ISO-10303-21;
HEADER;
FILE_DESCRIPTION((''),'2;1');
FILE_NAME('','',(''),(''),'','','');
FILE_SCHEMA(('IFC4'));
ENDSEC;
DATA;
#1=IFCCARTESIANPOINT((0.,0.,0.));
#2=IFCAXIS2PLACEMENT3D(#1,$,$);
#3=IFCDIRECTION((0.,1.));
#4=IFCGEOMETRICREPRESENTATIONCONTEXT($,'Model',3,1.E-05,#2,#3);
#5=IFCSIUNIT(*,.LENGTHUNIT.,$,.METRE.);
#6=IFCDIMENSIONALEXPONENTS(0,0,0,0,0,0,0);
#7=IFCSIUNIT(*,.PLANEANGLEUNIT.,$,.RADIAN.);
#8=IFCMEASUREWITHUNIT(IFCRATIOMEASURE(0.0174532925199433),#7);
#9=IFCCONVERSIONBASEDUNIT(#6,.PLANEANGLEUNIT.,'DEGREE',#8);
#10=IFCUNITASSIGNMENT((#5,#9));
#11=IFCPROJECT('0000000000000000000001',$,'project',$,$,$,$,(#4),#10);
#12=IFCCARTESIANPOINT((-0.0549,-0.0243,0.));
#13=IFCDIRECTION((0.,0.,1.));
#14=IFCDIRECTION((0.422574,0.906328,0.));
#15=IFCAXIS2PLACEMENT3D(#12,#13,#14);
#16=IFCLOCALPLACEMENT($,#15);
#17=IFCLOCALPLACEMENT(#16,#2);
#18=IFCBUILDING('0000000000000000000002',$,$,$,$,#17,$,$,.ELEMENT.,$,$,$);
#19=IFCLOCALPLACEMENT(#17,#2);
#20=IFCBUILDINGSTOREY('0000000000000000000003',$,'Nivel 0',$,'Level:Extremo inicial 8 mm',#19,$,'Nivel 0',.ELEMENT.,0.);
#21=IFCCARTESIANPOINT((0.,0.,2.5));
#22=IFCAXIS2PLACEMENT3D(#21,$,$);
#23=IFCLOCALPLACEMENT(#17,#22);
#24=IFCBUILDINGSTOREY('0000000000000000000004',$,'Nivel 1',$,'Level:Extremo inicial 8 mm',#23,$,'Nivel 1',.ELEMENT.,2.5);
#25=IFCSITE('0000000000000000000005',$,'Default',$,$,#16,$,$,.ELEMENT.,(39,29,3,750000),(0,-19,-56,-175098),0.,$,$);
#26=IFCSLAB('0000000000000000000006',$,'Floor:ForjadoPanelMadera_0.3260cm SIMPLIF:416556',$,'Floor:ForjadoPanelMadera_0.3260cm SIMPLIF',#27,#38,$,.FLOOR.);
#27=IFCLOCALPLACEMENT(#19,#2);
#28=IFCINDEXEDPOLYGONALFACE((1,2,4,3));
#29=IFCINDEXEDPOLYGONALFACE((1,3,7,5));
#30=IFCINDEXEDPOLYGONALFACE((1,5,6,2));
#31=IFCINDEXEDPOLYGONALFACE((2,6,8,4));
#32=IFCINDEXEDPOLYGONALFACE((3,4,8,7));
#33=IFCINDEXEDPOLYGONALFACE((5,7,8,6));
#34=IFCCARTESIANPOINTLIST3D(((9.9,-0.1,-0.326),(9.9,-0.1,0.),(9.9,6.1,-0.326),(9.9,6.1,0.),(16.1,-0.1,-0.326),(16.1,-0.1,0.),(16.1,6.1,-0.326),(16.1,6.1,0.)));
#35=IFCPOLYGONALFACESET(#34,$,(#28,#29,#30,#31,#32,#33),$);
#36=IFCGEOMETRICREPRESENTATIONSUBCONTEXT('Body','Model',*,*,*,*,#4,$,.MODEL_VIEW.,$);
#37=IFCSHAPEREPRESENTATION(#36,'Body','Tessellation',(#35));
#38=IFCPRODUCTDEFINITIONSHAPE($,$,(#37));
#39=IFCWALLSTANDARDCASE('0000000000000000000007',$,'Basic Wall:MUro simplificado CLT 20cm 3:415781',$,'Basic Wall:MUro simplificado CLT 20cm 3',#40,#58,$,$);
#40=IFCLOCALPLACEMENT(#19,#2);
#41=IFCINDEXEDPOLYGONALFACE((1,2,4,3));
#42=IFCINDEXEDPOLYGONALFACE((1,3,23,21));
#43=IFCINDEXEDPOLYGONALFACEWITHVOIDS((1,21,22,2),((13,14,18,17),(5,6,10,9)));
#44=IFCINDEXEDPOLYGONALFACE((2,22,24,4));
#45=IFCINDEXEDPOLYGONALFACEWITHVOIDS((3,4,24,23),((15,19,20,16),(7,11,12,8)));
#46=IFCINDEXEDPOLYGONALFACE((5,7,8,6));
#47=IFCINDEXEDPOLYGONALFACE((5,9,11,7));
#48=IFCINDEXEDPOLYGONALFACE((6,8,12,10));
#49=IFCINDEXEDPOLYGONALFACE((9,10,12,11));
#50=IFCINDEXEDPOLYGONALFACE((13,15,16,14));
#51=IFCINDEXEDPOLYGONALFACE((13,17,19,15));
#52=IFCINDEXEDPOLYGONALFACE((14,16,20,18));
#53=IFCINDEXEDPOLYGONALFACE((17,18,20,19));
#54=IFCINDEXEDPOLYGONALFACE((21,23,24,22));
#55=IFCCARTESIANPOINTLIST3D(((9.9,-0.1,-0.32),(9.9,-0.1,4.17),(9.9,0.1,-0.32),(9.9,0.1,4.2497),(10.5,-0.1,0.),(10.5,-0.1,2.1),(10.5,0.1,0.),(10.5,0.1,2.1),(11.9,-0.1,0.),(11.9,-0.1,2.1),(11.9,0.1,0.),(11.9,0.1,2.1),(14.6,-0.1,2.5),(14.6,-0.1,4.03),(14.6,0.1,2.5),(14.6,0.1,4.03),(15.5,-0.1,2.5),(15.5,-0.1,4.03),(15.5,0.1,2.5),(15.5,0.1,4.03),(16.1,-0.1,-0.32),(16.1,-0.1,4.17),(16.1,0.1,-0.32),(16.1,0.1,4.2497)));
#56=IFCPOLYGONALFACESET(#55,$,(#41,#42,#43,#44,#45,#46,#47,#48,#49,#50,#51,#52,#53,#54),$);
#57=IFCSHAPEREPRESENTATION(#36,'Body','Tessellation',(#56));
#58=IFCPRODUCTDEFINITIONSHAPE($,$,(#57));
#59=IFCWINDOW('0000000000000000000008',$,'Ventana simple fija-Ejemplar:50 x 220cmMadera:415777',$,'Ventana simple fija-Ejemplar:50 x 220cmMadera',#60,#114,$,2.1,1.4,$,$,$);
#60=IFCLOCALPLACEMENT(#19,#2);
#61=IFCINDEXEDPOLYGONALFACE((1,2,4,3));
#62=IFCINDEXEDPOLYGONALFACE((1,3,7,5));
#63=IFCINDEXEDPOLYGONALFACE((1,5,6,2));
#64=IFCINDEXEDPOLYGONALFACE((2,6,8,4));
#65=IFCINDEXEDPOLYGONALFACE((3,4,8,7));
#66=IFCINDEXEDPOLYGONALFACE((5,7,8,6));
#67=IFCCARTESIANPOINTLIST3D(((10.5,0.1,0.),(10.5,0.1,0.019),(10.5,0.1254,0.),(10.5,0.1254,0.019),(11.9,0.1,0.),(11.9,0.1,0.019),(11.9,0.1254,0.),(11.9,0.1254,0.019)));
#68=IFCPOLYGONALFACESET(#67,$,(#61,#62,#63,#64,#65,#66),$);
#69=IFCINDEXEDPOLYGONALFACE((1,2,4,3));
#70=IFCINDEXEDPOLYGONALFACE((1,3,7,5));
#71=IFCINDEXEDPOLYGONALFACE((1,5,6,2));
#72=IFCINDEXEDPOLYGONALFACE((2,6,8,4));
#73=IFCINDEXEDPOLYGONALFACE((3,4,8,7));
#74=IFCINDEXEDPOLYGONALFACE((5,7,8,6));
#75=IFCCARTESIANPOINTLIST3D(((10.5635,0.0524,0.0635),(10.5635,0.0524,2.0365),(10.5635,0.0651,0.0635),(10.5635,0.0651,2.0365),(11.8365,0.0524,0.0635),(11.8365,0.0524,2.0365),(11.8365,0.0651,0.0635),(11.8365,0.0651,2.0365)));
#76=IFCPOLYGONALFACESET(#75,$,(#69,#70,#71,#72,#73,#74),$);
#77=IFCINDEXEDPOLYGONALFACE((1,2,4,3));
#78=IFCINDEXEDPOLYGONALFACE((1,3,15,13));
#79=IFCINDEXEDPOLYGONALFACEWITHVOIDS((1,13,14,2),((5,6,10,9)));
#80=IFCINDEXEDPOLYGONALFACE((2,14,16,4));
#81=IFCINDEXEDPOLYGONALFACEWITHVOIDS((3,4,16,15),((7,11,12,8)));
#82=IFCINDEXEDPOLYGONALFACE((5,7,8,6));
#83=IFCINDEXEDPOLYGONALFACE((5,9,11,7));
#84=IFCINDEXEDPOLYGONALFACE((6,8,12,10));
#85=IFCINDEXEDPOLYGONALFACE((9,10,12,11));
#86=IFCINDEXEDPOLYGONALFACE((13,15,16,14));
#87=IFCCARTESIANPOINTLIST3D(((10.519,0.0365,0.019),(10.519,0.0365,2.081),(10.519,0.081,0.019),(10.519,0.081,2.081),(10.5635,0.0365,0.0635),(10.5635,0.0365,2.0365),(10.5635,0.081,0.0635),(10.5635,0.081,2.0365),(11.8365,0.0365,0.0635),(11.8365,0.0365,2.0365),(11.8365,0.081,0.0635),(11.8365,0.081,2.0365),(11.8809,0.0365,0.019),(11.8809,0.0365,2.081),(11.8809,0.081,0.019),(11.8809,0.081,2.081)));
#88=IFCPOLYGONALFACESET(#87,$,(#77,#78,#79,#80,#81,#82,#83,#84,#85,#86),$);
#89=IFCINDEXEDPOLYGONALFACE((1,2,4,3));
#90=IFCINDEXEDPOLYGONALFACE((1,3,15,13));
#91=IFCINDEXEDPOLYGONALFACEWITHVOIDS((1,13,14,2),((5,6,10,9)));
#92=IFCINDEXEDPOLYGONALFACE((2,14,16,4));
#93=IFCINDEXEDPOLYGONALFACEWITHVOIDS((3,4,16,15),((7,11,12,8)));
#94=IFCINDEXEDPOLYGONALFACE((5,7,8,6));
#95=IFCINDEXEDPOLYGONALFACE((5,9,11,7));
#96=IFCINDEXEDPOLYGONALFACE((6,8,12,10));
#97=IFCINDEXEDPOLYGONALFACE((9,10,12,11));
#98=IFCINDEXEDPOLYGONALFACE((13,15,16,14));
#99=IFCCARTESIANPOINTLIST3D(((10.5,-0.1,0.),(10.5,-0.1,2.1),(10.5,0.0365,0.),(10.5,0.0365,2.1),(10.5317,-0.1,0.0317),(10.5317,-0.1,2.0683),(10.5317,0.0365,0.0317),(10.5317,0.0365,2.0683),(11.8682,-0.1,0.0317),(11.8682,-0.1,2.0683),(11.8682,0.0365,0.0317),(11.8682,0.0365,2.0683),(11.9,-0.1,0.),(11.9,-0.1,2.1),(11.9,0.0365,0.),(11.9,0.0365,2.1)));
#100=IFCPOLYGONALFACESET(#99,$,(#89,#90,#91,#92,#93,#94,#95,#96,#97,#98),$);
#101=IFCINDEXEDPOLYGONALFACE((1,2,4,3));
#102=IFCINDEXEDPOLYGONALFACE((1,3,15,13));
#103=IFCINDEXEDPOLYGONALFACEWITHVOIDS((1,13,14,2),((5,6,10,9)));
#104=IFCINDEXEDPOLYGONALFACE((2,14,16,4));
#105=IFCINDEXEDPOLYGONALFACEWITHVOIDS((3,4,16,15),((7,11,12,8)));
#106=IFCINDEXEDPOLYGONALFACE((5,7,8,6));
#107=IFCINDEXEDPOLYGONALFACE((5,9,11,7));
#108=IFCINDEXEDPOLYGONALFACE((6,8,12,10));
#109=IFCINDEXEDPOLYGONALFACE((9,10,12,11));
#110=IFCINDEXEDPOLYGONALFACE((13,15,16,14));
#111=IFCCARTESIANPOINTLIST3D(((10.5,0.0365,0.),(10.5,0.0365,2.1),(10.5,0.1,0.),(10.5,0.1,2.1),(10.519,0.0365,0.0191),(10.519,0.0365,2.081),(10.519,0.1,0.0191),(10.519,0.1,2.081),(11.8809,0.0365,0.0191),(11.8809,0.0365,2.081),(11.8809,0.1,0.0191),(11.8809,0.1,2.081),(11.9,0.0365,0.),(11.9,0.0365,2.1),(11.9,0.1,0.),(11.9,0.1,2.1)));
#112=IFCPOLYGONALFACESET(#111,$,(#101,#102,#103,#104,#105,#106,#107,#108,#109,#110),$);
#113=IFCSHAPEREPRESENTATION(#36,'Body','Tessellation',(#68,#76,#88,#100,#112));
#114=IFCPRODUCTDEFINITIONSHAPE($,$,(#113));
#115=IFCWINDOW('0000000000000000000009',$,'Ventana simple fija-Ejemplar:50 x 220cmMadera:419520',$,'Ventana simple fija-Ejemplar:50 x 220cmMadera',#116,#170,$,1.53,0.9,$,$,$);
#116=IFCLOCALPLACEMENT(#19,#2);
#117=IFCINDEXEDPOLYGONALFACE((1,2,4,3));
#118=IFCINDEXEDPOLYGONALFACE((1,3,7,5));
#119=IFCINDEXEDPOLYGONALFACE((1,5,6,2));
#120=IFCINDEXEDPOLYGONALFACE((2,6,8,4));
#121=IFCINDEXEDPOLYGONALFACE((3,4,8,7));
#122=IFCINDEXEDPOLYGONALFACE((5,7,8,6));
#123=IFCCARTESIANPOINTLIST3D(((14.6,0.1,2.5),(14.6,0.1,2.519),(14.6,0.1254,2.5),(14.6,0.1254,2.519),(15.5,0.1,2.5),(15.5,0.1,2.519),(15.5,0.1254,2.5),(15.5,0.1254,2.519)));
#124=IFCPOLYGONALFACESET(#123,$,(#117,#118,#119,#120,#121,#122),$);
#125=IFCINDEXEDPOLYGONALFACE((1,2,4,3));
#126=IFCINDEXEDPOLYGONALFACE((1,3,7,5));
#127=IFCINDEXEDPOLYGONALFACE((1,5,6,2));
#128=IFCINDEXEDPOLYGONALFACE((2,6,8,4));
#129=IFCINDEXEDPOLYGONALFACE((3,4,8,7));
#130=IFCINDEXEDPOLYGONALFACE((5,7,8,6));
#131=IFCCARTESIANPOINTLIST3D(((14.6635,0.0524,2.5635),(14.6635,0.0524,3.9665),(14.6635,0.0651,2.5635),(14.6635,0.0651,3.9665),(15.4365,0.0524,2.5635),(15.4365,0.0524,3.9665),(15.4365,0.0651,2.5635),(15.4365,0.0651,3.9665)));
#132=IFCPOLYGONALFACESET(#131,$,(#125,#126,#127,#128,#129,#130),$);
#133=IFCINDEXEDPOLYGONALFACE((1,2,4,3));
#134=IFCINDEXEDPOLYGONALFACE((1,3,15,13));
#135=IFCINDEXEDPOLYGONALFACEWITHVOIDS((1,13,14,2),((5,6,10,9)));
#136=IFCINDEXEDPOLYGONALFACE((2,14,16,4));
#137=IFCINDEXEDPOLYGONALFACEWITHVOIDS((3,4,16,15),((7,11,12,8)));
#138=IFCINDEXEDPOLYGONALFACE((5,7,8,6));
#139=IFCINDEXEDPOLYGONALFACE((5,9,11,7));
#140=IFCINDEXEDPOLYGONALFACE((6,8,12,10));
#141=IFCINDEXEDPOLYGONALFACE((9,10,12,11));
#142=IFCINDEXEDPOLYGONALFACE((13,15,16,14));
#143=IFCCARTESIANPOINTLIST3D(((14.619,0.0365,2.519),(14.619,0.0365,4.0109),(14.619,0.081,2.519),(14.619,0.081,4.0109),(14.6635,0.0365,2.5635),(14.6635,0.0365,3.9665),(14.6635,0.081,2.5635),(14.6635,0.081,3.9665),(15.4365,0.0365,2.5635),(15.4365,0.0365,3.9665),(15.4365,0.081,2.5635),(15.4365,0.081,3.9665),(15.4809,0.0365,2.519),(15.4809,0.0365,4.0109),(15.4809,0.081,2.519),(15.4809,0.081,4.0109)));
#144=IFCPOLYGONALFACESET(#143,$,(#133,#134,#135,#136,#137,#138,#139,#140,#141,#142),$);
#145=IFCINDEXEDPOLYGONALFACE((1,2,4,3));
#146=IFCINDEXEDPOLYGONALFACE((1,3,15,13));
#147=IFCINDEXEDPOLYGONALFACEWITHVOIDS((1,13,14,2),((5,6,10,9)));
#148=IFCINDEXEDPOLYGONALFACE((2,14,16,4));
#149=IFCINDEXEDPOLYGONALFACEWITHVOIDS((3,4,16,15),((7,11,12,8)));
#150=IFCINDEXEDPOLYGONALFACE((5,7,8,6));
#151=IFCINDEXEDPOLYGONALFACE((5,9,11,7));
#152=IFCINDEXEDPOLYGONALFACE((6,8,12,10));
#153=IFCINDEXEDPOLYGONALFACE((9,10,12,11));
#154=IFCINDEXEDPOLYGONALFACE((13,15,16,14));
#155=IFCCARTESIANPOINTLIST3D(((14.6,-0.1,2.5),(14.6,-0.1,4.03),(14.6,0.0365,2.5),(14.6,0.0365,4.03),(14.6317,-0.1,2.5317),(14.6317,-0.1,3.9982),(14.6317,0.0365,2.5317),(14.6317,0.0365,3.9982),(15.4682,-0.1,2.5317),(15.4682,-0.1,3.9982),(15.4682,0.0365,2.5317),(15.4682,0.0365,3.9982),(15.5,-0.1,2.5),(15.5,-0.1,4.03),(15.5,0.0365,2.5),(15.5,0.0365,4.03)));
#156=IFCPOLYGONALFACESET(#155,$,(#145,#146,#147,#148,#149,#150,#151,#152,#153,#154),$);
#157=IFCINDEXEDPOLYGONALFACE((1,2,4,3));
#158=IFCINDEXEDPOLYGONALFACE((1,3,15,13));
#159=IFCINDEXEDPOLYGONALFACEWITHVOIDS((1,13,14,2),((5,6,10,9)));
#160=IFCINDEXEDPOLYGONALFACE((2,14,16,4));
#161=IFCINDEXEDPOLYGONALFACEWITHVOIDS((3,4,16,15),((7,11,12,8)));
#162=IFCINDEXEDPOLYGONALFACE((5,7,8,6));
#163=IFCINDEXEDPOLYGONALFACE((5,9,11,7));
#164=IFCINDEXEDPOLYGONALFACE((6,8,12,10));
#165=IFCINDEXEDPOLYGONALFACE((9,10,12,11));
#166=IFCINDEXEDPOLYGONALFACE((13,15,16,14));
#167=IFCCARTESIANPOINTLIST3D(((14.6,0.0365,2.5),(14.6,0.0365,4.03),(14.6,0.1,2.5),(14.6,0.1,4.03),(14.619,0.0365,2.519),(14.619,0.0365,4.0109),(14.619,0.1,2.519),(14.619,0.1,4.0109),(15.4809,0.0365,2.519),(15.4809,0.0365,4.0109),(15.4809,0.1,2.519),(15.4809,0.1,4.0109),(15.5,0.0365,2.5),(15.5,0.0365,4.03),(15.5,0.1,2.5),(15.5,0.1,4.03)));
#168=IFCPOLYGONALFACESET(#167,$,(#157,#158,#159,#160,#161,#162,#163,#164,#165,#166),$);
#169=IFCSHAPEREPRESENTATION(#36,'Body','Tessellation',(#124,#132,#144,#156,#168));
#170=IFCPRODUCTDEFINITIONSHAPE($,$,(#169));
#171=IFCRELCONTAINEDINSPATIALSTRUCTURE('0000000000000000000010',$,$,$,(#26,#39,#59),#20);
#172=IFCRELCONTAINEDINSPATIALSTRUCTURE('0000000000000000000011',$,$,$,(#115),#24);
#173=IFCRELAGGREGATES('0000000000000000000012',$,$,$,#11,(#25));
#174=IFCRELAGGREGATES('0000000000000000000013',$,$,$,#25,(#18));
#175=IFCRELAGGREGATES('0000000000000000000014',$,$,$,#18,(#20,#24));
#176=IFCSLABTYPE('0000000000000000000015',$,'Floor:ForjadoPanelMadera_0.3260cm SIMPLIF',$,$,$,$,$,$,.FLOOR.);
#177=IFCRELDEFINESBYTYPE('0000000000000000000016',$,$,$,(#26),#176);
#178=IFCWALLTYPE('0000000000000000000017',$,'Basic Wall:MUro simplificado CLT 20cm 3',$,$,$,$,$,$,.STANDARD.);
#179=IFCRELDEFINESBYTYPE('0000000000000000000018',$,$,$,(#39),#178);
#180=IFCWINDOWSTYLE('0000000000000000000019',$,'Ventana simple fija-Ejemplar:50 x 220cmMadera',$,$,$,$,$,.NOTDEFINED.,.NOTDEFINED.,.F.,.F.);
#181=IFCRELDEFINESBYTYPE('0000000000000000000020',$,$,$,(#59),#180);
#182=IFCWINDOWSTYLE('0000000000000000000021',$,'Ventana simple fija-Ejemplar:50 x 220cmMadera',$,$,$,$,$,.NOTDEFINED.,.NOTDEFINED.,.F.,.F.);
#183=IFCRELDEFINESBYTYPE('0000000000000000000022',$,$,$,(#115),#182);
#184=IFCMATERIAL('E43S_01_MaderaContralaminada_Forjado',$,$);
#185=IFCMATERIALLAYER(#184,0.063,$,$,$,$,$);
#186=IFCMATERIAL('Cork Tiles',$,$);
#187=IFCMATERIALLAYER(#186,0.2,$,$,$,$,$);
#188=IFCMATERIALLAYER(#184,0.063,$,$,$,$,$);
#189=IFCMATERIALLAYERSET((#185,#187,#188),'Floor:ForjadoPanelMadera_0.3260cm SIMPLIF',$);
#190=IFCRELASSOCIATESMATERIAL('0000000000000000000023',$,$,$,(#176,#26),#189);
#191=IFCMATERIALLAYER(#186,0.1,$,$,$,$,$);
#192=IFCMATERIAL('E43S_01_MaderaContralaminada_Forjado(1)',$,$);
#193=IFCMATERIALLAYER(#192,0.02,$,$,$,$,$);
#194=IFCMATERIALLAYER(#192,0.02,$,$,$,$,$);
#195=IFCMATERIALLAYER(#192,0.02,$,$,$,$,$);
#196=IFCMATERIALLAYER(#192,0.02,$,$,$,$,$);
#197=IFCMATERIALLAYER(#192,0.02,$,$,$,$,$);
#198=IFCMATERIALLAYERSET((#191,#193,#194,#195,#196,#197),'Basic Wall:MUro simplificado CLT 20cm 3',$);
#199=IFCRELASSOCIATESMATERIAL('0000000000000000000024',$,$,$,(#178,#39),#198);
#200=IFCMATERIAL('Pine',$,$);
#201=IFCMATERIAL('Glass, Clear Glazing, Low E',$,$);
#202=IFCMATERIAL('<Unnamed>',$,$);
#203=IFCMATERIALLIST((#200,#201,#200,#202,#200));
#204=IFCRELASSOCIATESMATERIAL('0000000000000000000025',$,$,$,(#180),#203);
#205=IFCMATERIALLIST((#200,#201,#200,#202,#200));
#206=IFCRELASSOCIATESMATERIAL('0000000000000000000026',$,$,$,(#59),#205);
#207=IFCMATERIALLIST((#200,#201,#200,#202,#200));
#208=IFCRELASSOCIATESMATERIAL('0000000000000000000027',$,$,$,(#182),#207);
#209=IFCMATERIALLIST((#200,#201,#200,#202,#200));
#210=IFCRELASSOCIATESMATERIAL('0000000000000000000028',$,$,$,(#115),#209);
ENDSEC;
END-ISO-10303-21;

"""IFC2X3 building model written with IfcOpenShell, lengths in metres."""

from ifc_helpers import new_model, entity, si_unit, converted_unit, direction, frame, frame_2d, origin, origin_2d_with_axis, place, context, subcontext, project, spatial, polyline, rectangle, outline, extrude, clip, bounded_halfspace, source, transform, mapped, material, material_list, layer, layer_set, layer_usage, type_object, type_shapes, element, fill, save


model = new_model("IFC2X3")

# Units and contexts
model_context = context("Model", 3, precision=1e-05, world=origin(), true_north=direction((0.0, 1.0)))
body_context = subcontext(model_context, "Body", "Model", "MODEL_VIEW")
ifc_project = project(units=[si_unit("LENGTHUNIT", "METRE"), converted_unit("PLANEANGLEUNIT", "DEGREE", entity("IfcRatioMeasure", 0.0174532925199433), si_unit("PLANEANGLEUNIT", "RADIAN"), dimensions=[0, 0, 0, 0, 0, 0, 0])], contexts=[model_context])

# Site, building, storey
site_placement = place(None, frame((-0.0549, -0.0243, 0.0), z_axis=(0.0, 0.0, 1.0), x_axis=(0.422574, 0.906328, 0.0)))
site = spatial("IfcSite", under=ifc_project, at=site_placement, Name="Default", CompositionType="ELEMENT", RefLatitude=(39, 29, 3, 750000), RefLongitude=(0, -19, -56, -175098), RefElevation=0.0)
building_placement = place(site_placement, origin())
building = spatial("IfcBuilding", under=site, at=building_placement, CompositionType="ELEMENT")
storey_1_placement = place(building_placement, origin())
storey_1 = spatial("IfcBuildingStorey", under=building, at=storey_1_placement, Name="Nivel 0", ObjectType="Level:Extremo inicial 8 mm", LongName="Nivel 0", CompositionType="ELEMENT", Elevation=0.0)

# Slab
ifc_material_1 = material(Name="E43S_01_MaderaContralaminada_Forjado")
ifc_layer_1 = layer(ifc_material_1, 0.063)
ifc_material_2 = material(Name="Cork Tiles")
ifc_layer_2 = layer(ifc_material_2, 0.2)
ifc_layer_3 = layer(ifc_material_1, 0.063)
ifc_layer_set_1 = layer_set([ifc_layer_1, ifc_layer_2, ifc_layer_3], Name="Floor:ForjadoPanelMadera_0.3260cm SIMPLIF")
ifc_layer_usage_1 = layer_usage(ifc_layer_set_1, "AXIS3", "POSITIVE", 0.0)
slab_type = type_object("IfcSlabType", Name="Floor:ForjadoPanelMadera_0.3260cm SIMPLIF", PredefinedType="FLOOR", material=ifc_layer_set_1)
slab_placement = place(storey_1_placement, origin())
element("IfcSlab", 1, at=slab_placement, inside=storey_1, type_object=slab_type, material=ifc_layer_usage_1, Name="Floor:ForjadoPanelMadera_0.3260cm SIMPLIF:416556", ObjectType="Floor:ForjadoPanelMadera_0.3260cm SIMPLIF", PredefinedType="FLOOR", context=body_context, shape_type="SweptSolid", body=[
    extrude(rectangle(XDim=6.2, YDim=6.2, at=frame_2d((0.0, 0.0), x_axis=(1.0, 0.0))), frame((13.0, 3.0, 0.0), z_axis=(0.0, 0.0, -1.0), x_axis=(0.0, 1.0, 0.0)), (0.0, 0.0, 1.0), 0.326),
])

# Wall, openings, window
ifc_layer_4 = layer(ifc_material_2, 0.1)
ifc_material_3 = material(Name="E43S_01_MaderaContralaminada_Forjado(1)")
ifc_layer_5 = layer(ifc_material_3, 0.02)
ifc_layer_6 = layer(ifc_material_3, 0.02)
ifc_layer_7 = layer(ifc_material_3, 0.02)
ifc_layer_8 = layer(ifc_material_3, 0.02)
ifc_layer_9 = layer(ifc_material_3, 0.02)
ifc_layer_set_2 = layer_set([ifc_layer_4, ifc_layer_5, ifc_layer_6, ifc_layer_7, ifc_layer_8, ifc_layer_9], Name="Basic Wall:MUro simplificado CLT 20cm 3")
ifc_layer_usage_2 = layer_usage(ifc_layer_set_2, "AXIS2", "NEGATIVE", 0.1)
wall_type = type_object("IfcWallType", Name="Basic Wall:MUro simplificado CLT 20cm 3", PredefinedType="STANDARD", material=ifc_layer_set_2)
wall_1_placement = place(storey_1_placement, frame((16.1, 0.0, -0.32), z_axis=(0.0, 0.0, 1.0), x_axis=(-1.0, 0.0, 0.0)))
wall_1 = element("IfcWallStandardCase", 2, at=wall_1_placement, inside=storey_1, type_object=wall_type, material=ifc_layer_usage_2, Name="Basic Wall:MUro simplificado CLT 20cm 3:415781", ObjectType="Basic Wall:MUro simplificado CLT 20cm 3", context=body_context, shape_type="Clipping", body=[
    clip(extrude(rectangle(XDim=6.2, YDim=0.2, at=frame_2d((3.1, 0.0), x_axis=(-1.0, 0.0))), origin(), (0.0, 0.0, 1.0), 4.5697), bounded_halfspace(frame((0.0, -0.1, 4.5697), z_axis=(0.0, 0.370288, 0.928917), x_axis=(-1.0, 0.0, 0.0)), False, frame((0.0, -0.1, 4.5697)), polyline([(0.0, 0.0), (0.2, 0.0), (6.0, 0.0), (6.2, 0.0), (6.2, 0.2), (0.0, 0.2), (0.0, 0.0)]))),
])
opening_1_placement = place(wall_1_placement, frame((5.6, 0.1, 0.32)))
opening_1 = element("IfcOpeningElement", 3, at=opening_1_placement, cuts=wall_1, ObjectType="Opening", context=body_context, shape_type="SweptSolid", body=[
    extrude(rectangle(XDim=2.1, YDim=1.4, at=frame_2d((1.05, 0.7), x_axis=(-1.0, 0.0))), frame((0.0, 0.0, 0.0), z_axis=(0.0, -1.0, 0.0), x_axis=(0.0, 0.0, 1.0)), (0.0, 0.0, 1.0), 0.2),
])
opening_2_placement = place(wall_1_placement, frame((1.5, 0.1, 2.82)))
opening_2 = element("IfcOpeningElement", 4, at=opening_2_placement, cuts=wall_1, ObjectType="Opening", context=body_context, shape_type="SweptSolid", body=[
    extrude(rectangle(XDim=1.53, YDim=0.9, at=frame_2d((0.765, 0.45), x_axis=(-1.0, 0.0))), frame((0.0, 0.0, 0.0), z_axis=(0.0, -1.0, 0.0), x_axis=(0.0, 0.0, 1.0)), (0.0, 0.0, 1.0), 0.2),
])
ifc_material_4 = material(Name="Pine")
ifc_material_5 = material(Name="Glass, Clear Glazing, Low E")
ifc_material_6 = material(Name="<Unnamed>")
ifc_material_list_1 = material_list([ifc_material_4, ifc_material_5, ifc_material_4, ifc_material_6, ifc_material_4])
ifc_material_list_2 = material_list([ifc_material_4, ifc_material_5, ifc_material_4, ifc_material_6, ifc_material_4])
window_style_1 = type_object("IfcWindowStyle", Name="Ventana simple fija-Ejemplar:50 x 220cmMadera", ConstructionType="NOTDEFINED", OperationType="NOTDEFINED", ParameterTakesPrecedence=False, Sizeable=False, material=ifc_material_list_2)
shared_shape_1 = source(origin(), body_context, "Body", "SweptSolid", [
    extrude(rectangle(XDim=1.4, YDim=0.0254, at=origin_2d_with_axis()), frame((0.7762, 0.2127, 0.0), z_axis=(0.0, 0.0, 1.0), x_axis=(-1.0, 0.0, 0.0)), (0.0, 0.0, 1.0), 0.019),
    extrude(rectangle(XDim=1.273, YDim=0.0127, at=frame_2d((0.0, 0.0), x_axis=(1.0, 0.0))), frame((0.7762, 0.1588, 0.0635)), (0.0, 0.0, 1.0), 1.973),
    extrude(outline(polyline([(-0.681, -1.031), (0.681, -1.031), (0.681, 1.031), (-0.681, 1.031), (-0.681, -1.031)]), holes=[polyline([(-0.6365, -0.9865), (-0.6365, 0.9865), (0.6365, 0.9865), (0.6365, -0.9865), (-0.6365, -0.9865)])]), frame((0.7762, 0.181, 1.05), z_axis=(0.0, -1.0, 0.0), x_axis=(-1.0, 0.0, 0.0)), (0.0, 0.0, 1.0), 0.0445),
    extrude(outline(polyline([(-0.7, -1.05), (0.7, -1.05), (0.7, 1.05), (-0.7, 1.05), (-0.7, -1.05)]), holes=[polyline([(-0.6683, -1.0183), (-0.6683, 1.0183), (0.6682, 1.0183), (0.6682, -1.0183), (-0.6683, -1.0183)])]), frame((0.7762, 0.1366, 1.05), z_axis=(0.0, -1.0, 0.0), x_axis=(-1.0, 0.0, 0.0)), (0.0, 0.0, 1.0), 0.1366),
    extrude(outline(polyline([(-1.05, -0.7), (1.05, -0.7), (1.05, 0.7), (-1.05, 0.7), (-1.05, -0.7)]), holes=[polyline([(-1.031, -0.6809), (-1.031, 0.681), (1.031, 0.681), (1.031, -0.6809), (-1.031, -0.6809)])]), frame((0.7762, 0.2, 1.05), z_axis=(0.0, -1.0, 0.0), x_axis=(0.0, 0.0, -1.0)), (0.0, 0.0, 1.0), 0.0635),
])
type_shapes(window_style_1, [shared_shape_1])
window_1_placement = place(opening_1_placement, frame((0.0762, 0.0, 0.0), z_axis=(0.0, 0.0, 1.0), x_axis=(-1.0, 0.0, 0.0)))
window_1 = element("IfcWindow", 5, at=window_1_placement, inside=storey_1, type_object=window_style_1, material=ifc_material_list_1, Name="Ventana simple fija-Ejemplar:50 x 220cmMadera:415777", ObjectType="Ventana simple fija-Ejemplar:50 x 220cmMadera", OverallHeight=2.1, OverallWidth=1.4, context=body_context, shape_type="MappedRepresentation", body=[
    mapped(shared_shape_1, transform((0.0, 0.0, 0.0), scale=1.0)),
])
fill(opening_1, window_1)

# Shared definitions
storey_2_placement = place(building_placement, frame((0.0, 0.0, 2.5)))
storey_2 = spatial("IfcBuildingStorey", under=building, at=storey_2_placement, Name="Nivel 1", ObjectType="Level:Extremo inicial 8 mm", LongName="Nivel 1", CompositionType="ELEMENT", Elevation=2.5)

# Window
ifc_material_list_3 = material_list([ifc_material_4, ifc_material_5, ifc_material_4, ifc_material_6, ifc_material_4])
ifc_material_list_4 = material_list([ifc_material_4, ifc_material_5, ifc_material_4, ifc_material_6, ifc_material_4])
window_style_2 = type_object("IfcWindowStyle", Name="Ventana simple fija-Ejemplar:50 x 220cmMadera", ConstructionType="NOTDEFINED", OperationType="NOTDEFINED", ParameterTakesPrecedence=False, Sizeable=False, material=ifc_material_list_4)
shared_shape_2 = source(origin(), body_context, "Body", "SweptSolid", [
    extrude(rectangle(XDim=0.9, YDim=0.0254, at=origin_2d_with_axis()), frame((0.5262, 0.2127, 0.0), z_axis=(0.0, 0.0, 1.0), x_axis=(-1.0, 0.0, 0.0)), (0.0, 0.0, 1.0), 0.019),
    extrude(rectangle(XDim=0.773, YDim=0.0127, at=frame_2d((0.0, 0.0), x_axis=(1.0, 0.0))), frame((0.5262, 0.1588, 0.0635)), (0.0, 0.0, 1.0), 1.403),
    extrude(outline(polyline([(-0.431, -0.7459), (0.431, -0.7459), (0.431, 0.7459), (-0.431, 0.7459), (-0.431, -0.7459)]), holes=[polyline([(-0.3865, -0.7015), (-0.3865, 0.7015), (0.3865, 0.7015), (0.3865, -0.7015), (-0.3865, -0.7015)])]), frame((0.5262, 0.181, 0.765), z_axis=(0.0, -1.0, 0.0), x_axis=(-1.0, 0.0, 0.0)), (0.0, 0.0, 1.0), 0.0445),
    extrude(outline(polyline([(-0.45, -0.765), (0.45, -0.765), (0.45, 0.765), (-0.45, 0.765), (-0.45, -0.765)]), holes=[polyline([(-0.4183, -0.7332), (-0.4183, 0.7332), (0.4183, 0.7332), (0.4183, -0.7332), (-0.4183, -0.7332)])]), frame((0.5262, 0.1366, 0.765), z_axis=(0.0, -1.0, 0.0), x_axis=(-1.0, 0.0, 0.0)), (0.0, 0.0, 1.0), 0.1366),
    extrude(outline(polyline([(-0.765, -0.45), (0.765, -0.45), (0.765, 0.45), (-0.765, 0.45), (-0.765, -0.45)]), holes=[polyline([(-0.7459, -0.431), (-0.7459, 0.431), (0.7459, 0.431), (0.7459, -0.431), (-0.7459, -0.431)])]), frame((0.5262, 0.2, 0.765), z_axis=(0.0, -1.0, 0.0), x_axis=(0.0, 0.0, -1.0)), (0.0, 0.0, 1.0), 0.0635),
])
type_shapes(window_style_2, [shared_shape_2])
window_2_placement = place(opening_2_placement, frame((0.0762, 0.0, 0.0), z_axis=(0.0, 0.0, 1.0), x_axis=(-1.0, 0.0, 0.0)))
window_2 = element("IfcWindow", 6, at=window_2_placement, inside=storey_2, type_object=window_style_2, material=ifc_material_list_3, Name="Ventana simple fija-Ejemplar:50 x 220cmMadera:419520", ObjectType="Ventana simple fija-Ejemplar:50 x 220cmMadera", OverallHeight=1.53, OverallWidth=0.9, context=body_context, shape_type="MappedRepresentation", body=[
    mapped(shared_shape_2, transform((0.0, 0.0, 0.0), scale=1.0)),
])
fill(opening_2, window_2)

save(model, "model.ifc")
